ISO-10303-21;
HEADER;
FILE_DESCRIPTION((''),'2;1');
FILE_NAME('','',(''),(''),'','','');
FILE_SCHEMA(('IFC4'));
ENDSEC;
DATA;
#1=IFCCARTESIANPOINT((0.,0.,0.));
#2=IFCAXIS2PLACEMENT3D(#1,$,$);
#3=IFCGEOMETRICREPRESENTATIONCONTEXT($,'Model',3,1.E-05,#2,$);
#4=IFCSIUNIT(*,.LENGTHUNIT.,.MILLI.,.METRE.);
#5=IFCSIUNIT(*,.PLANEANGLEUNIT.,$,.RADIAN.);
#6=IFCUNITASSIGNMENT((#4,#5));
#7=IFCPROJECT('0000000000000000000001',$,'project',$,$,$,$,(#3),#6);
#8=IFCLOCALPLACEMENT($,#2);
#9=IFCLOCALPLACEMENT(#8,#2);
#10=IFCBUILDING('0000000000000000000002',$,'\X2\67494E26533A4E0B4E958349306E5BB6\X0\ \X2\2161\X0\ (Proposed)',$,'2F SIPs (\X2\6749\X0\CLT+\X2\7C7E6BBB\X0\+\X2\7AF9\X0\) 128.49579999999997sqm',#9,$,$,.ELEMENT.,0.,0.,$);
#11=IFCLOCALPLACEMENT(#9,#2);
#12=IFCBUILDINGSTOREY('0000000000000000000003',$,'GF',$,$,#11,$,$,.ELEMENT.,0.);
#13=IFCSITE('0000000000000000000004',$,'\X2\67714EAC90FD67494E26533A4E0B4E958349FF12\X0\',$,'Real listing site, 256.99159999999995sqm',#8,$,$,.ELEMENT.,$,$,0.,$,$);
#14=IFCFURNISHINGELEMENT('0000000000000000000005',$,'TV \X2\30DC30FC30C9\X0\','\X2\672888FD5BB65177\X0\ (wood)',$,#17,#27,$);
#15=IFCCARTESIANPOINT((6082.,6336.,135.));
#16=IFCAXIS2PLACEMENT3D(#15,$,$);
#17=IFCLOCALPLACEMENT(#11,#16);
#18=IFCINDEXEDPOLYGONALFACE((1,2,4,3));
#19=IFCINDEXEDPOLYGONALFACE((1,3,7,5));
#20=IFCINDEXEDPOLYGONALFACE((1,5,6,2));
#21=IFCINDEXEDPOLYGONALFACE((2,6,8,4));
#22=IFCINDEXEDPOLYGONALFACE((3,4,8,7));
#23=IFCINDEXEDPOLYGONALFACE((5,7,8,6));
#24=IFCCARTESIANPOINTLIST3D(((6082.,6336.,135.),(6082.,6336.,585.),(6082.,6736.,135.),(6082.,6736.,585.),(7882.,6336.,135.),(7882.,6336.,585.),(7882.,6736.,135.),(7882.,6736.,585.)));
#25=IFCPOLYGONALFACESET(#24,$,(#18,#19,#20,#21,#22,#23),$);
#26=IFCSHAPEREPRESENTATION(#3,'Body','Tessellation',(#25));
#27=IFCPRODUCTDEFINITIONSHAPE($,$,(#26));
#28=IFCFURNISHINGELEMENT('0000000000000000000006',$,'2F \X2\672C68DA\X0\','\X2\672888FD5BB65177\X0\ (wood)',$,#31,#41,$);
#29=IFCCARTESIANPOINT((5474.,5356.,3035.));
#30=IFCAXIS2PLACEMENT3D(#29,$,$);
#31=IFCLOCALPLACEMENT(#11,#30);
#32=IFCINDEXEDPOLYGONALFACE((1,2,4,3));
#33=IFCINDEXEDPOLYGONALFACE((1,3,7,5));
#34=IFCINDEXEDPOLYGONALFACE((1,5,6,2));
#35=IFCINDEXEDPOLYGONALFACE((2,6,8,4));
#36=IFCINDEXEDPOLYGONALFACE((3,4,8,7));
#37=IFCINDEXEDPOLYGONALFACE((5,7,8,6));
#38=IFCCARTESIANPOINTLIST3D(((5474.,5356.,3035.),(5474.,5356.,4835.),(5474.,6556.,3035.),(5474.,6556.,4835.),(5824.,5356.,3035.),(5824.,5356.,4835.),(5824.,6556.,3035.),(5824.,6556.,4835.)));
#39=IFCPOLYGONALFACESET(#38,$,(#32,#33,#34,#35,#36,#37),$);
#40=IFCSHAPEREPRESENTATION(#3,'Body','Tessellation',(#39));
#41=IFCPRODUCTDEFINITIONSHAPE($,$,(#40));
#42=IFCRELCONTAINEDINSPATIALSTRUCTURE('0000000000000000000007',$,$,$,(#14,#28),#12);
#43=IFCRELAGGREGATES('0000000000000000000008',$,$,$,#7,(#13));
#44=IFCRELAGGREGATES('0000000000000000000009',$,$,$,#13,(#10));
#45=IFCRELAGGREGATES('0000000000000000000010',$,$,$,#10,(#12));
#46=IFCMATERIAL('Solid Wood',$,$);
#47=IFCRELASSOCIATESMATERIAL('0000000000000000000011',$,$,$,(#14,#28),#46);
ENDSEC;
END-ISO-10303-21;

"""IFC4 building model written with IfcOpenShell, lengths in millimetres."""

from ifc_helpers import new_model, si_unit, frame, frame_2d, origin, place, context, project, spatial, rectangle, extrude, material, element, save


model = new_model("IFC4")

# Units and contexts
model_context = context("Model", 3, precision=1e-05, world=origin())
ifc_project = project(units=[si_unit("LENGTHUNIT", "METRE", prefix="MILLI"), si_unit("PLANEANGLEUNIT", "RADIAN")], contexts=[model_context])

# Site, building, storey
site_placement = place(None, origin())
site = spatial("IfcSite", under=ifc_project, at=site_placement, Name="東京都杉並区下井草２", ObjectType="Real listing site, 256.99159999999995sqm", CompositionType="ELEMENT", RefElevation=0.0)
building_placement = place(site_placement, origin())
building = spatial("IfcBuilding", under=site, at=building_placement, Name="杉並区下井草の家 Ⅱ (Proposed)", ObjectType="2F SIPs (杉CLT+籾殻+竹) 128.49579999999997sqm", CompositionType="ELEMENT", ElevationOfRefHeight=0.0, ElevationOfTerrain=0.0)
storey_placement = place(building_placement, origin())
storey = spatial("IfcBuildingStorey", under=building, at=storey_placement, Name="GF", CompositionType="ELEMENT", Elevation=0.0)

# Shared definitions
ifc_material_1 = material(Name="Solid Wood")

# Furnishing elements
furnishing_1_placement = place(storey_placement, frame((6082.0, 6336.0, 135.0)))
element("IfcFurnishingElement", 1, at=furnishing_1_placement, inside=storey, material=ifc_material_1, Name="TV ボード", Description="木製家具 (wood)", context=model_context, shape_type="SweptSolid", body=[
    extrude(rectangle(XDim=1800.0, YDim=400.0, at=frame_2d((900.0, 200.0))), frame((6082.0, 6336.0, 135.0)), (0.0, 0.0, 1.0), 450.0),
])
furnishing_2_placement = place(storey_placement, frame((5474.0, 5356.0, 3035.0)))
element("IfcFurnishingElement", 2, at=furnishing_2_placement, inside=storey, material=ifc_material_1, Name="2F 本棚", Description="木製家具 (wood)", context=model_context, shape_type="SweptSolid", body=[
    extrude(rectangle(XDim=350.0, YDim=1200.0, at=frame_2d((175.0, 600.0))), frame((5474.0, 5356.0, 3035.0)), (0.0, 0.0, 1.0), 1800.0),
])

save(model, "model.ifc")
